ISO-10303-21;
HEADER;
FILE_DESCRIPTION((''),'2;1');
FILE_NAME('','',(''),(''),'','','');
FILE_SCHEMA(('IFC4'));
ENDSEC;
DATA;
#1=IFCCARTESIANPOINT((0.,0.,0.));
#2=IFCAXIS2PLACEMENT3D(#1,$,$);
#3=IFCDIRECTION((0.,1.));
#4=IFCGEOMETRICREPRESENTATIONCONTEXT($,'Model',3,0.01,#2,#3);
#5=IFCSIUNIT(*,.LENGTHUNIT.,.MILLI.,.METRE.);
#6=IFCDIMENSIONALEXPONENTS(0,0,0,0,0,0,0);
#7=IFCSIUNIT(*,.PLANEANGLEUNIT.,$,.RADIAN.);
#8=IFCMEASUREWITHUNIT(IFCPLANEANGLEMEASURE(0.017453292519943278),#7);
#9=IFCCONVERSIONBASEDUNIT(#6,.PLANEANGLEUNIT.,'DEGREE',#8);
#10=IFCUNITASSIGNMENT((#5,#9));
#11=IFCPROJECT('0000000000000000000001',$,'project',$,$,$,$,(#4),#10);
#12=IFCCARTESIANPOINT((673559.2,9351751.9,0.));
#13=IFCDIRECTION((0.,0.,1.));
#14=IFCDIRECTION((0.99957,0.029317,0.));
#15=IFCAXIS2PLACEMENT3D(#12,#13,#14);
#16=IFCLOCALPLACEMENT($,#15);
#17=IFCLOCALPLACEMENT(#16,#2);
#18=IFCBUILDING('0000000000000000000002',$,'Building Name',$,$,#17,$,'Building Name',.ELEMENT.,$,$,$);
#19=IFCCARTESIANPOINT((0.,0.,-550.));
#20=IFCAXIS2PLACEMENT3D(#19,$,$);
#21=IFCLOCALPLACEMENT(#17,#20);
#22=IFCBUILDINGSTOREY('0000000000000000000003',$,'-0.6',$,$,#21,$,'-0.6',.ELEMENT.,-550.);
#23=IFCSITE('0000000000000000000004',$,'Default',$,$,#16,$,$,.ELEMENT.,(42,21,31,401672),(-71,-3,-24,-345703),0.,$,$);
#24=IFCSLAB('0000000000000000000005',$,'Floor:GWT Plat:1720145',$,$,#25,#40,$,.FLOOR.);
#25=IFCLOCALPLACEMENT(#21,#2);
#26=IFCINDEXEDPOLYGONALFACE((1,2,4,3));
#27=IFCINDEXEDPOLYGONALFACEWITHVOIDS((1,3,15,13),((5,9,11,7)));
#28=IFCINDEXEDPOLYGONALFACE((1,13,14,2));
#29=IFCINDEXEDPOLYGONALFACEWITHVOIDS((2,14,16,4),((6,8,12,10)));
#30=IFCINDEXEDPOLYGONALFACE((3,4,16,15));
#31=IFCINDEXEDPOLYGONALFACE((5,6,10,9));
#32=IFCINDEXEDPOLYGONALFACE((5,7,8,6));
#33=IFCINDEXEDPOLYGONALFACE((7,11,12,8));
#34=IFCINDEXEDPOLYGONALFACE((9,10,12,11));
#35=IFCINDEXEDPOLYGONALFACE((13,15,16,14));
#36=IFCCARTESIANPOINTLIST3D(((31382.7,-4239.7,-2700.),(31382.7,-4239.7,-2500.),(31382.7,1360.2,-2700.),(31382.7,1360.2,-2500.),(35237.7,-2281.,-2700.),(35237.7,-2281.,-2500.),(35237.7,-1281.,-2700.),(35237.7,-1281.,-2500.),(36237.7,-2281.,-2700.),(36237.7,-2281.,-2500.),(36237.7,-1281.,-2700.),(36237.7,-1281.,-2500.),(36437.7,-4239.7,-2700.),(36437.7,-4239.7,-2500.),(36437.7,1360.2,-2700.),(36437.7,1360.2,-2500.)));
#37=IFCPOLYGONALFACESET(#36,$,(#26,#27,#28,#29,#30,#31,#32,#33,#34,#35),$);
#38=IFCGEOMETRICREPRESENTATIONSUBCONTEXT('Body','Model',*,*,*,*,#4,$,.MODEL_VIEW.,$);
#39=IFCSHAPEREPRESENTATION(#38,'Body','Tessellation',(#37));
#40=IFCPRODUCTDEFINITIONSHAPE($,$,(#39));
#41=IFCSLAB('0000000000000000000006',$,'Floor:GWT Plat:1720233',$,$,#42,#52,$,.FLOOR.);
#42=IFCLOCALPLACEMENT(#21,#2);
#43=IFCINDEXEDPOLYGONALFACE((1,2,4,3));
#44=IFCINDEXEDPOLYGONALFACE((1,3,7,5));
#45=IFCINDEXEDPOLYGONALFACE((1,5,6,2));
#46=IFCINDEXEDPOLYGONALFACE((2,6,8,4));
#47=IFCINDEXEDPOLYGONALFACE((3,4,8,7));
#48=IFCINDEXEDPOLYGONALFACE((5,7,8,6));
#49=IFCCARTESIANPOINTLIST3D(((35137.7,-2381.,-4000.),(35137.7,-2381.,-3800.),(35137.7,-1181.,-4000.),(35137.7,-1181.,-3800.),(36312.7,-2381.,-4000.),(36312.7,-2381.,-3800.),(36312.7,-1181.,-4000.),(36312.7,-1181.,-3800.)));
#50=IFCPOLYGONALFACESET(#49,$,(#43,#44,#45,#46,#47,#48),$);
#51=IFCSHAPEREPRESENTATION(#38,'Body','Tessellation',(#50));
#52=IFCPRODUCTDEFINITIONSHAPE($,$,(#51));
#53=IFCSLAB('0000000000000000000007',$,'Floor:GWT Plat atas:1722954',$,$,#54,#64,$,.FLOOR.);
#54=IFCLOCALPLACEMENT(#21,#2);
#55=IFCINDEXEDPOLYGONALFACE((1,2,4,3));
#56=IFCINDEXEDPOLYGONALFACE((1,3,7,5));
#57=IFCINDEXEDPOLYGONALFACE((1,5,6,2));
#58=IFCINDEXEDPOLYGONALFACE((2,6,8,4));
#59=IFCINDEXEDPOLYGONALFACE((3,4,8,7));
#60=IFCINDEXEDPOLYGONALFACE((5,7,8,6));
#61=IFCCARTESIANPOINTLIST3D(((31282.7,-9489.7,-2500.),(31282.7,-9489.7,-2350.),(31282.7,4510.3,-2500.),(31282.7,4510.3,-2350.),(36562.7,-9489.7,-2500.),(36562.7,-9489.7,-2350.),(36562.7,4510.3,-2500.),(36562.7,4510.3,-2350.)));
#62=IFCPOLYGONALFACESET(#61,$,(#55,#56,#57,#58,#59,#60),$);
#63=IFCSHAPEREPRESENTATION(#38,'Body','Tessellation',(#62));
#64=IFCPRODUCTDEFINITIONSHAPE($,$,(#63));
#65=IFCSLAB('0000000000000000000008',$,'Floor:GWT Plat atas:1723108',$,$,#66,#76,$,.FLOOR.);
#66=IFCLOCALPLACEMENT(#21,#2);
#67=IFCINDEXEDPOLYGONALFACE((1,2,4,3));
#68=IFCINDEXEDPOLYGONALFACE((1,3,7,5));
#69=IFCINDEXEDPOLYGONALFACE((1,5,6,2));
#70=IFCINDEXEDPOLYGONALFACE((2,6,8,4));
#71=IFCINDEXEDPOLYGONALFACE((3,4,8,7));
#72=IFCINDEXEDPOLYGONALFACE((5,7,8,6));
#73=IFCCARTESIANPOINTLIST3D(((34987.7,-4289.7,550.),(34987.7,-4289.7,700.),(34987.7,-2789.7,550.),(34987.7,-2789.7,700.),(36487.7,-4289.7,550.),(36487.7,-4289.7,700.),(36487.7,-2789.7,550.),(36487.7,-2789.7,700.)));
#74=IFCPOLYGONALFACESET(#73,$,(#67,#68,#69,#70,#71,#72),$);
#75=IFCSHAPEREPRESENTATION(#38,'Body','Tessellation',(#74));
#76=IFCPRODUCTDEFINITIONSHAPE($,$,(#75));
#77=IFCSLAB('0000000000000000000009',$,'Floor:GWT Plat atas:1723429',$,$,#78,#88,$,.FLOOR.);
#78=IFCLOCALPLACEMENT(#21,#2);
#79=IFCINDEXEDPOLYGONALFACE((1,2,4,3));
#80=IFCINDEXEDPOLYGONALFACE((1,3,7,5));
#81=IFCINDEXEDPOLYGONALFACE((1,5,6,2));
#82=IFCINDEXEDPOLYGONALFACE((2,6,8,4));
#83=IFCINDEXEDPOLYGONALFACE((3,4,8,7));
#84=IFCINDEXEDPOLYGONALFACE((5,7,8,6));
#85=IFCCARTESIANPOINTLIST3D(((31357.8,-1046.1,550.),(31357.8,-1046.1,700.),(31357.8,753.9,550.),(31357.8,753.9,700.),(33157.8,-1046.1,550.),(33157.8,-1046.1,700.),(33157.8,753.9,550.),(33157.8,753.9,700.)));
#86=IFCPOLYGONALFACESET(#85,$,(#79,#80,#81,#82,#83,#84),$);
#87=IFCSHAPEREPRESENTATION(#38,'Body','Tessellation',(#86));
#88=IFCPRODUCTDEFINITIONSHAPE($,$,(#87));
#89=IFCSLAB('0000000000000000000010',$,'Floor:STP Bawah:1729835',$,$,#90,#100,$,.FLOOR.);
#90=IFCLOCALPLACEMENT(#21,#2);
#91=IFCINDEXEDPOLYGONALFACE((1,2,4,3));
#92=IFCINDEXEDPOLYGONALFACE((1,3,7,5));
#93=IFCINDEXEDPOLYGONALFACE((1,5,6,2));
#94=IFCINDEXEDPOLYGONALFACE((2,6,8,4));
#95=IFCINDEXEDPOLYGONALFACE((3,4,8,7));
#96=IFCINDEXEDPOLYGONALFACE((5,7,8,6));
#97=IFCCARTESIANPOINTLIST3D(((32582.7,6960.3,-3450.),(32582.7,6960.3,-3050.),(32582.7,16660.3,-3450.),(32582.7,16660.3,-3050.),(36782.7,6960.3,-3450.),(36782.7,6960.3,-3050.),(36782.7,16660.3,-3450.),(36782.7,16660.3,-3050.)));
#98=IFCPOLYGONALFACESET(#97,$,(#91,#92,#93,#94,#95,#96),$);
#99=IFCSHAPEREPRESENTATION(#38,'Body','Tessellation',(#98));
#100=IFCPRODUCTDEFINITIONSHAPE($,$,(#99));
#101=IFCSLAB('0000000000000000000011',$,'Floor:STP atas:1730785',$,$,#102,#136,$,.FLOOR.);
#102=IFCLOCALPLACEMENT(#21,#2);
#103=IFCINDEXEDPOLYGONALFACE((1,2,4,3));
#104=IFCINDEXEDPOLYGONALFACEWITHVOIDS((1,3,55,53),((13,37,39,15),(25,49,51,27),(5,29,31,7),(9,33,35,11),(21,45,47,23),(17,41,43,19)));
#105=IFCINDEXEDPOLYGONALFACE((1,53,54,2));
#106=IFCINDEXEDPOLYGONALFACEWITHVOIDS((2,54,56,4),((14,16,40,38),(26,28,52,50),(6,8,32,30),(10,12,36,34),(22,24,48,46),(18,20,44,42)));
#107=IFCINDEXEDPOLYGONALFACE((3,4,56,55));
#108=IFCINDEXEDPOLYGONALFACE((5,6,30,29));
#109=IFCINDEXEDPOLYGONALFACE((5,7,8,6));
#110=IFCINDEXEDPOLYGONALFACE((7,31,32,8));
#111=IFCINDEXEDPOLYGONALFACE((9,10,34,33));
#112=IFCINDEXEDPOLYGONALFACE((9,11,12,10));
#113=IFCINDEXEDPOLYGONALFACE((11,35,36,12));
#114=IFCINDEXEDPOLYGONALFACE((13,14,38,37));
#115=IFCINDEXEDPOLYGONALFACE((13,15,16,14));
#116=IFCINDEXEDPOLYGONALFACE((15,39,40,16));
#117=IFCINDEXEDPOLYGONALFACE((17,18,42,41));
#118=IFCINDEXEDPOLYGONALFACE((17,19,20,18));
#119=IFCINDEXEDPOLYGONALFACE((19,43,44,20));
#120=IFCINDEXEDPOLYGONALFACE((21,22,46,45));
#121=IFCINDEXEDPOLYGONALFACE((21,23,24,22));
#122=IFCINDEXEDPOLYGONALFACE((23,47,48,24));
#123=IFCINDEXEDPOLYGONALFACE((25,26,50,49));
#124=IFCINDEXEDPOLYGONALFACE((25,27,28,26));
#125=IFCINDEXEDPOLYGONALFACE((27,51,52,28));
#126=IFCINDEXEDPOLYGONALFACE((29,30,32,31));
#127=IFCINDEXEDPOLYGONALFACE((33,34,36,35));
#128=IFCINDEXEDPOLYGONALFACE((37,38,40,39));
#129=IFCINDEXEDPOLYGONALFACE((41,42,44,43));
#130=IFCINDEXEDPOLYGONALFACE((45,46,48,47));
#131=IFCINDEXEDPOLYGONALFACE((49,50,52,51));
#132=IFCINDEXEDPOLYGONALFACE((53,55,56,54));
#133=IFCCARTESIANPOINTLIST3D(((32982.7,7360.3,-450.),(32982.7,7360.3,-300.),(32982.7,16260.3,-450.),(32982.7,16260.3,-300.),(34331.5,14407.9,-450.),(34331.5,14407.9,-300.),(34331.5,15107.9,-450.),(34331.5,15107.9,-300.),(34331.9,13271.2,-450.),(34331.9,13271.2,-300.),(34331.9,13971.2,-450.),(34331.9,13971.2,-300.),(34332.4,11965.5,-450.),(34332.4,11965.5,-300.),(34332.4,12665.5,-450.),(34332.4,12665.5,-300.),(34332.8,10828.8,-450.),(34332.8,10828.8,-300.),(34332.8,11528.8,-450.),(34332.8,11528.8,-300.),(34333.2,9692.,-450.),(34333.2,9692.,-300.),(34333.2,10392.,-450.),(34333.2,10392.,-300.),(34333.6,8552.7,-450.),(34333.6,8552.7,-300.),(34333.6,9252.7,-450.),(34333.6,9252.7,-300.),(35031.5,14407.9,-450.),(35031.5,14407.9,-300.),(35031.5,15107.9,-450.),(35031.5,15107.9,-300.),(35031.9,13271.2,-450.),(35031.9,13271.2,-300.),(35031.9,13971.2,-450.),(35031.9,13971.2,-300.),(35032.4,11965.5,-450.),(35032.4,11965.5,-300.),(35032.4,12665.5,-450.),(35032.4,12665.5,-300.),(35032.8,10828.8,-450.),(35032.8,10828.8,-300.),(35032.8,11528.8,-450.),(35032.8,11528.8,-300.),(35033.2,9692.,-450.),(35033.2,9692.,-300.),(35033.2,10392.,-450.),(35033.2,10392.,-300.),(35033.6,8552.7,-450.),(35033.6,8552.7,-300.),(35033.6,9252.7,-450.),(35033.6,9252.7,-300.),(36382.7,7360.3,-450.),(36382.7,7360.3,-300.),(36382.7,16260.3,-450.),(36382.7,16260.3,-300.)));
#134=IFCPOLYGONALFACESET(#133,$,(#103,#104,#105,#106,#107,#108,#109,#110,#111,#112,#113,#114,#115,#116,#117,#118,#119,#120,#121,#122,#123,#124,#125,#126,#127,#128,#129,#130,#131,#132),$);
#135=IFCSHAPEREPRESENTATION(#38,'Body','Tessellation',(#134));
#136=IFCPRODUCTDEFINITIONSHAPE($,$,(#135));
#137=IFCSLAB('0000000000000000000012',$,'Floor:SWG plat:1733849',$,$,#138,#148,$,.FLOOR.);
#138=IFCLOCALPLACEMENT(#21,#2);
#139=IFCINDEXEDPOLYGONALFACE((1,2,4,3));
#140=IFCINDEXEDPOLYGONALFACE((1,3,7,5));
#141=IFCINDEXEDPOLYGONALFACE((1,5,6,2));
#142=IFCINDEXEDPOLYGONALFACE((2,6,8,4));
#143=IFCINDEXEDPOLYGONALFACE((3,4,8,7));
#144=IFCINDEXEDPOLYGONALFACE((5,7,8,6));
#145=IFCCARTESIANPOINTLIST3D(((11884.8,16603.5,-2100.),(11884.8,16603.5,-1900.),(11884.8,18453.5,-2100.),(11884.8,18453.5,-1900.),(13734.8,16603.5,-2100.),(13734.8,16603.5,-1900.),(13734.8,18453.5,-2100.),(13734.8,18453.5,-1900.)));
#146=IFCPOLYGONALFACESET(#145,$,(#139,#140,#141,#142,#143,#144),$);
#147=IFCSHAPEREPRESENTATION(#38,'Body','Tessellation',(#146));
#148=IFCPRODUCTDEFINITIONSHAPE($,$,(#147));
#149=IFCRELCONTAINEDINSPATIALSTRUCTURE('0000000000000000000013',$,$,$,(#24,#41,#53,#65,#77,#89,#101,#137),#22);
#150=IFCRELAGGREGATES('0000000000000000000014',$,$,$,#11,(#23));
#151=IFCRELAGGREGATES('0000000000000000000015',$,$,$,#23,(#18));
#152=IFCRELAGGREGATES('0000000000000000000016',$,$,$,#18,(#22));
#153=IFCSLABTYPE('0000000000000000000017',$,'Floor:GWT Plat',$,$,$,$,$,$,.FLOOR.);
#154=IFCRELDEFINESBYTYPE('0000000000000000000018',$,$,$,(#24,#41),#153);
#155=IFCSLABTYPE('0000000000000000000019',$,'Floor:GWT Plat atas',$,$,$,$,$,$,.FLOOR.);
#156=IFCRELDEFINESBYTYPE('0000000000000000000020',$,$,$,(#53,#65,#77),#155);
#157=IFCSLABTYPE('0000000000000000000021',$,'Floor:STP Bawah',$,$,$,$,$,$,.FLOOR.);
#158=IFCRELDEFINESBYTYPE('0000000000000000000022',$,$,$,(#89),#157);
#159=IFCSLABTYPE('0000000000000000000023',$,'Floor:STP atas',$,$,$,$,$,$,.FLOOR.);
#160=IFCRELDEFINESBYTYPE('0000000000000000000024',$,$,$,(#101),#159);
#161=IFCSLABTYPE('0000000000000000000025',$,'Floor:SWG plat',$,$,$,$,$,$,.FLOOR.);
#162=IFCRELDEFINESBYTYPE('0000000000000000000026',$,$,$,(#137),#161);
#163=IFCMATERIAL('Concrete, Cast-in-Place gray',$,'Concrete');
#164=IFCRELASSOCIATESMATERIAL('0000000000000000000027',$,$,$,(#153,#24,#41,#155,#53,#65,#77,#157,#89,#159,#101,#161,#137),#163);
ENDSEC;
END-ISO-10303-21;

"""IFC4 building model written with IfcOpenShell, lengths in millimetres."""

from ifc_helpers import new_model, entity, si_unit, converted_unit, direction, frame, origin, place, context, subcontext, project, spatial, indexed_curve, outline, extrude, material, type_object, element, save


model = new_model("IFC4")

# Units and contexts
model_context = context("Model", 3, precision=0.01, world=origin(), true_north=direction((0.0, 1.0)))
body_context = subcontext(model_context, "Body", "Model", "MODEL_VIEW")
ifc_project = project(units=[si_unit("LENGTHUNIT", "METRE", prefix="MILLI"), converted_unit("PLANEANGLEUNIT", "DEGREE", entity("IfcPlaneAngleMeasure", 0.017453292519943278), si_unit("PLANEANGLEUNIT", "RADIAN"), dimensions=[0, 0, 0, 0, 0, 0, 0])], contexts=[model_context])

# Site, building, storey
site_placement = place(None, frame((673559.2, 9351751.9, 0.0), z_axis=(0.0, 0.0, 1.0), x_axis=(0.99957, 0.029317, 0.0)))
site = spatial("IfcSite", under=ifc_project, at=site_placement, Name="Default", CompositionType="ELEMENT", RefLatitude=(42, 21, 31, 401672), RefLongitude=(-71, -3, -24, -345703), RefElevation=0.0)
building_placement = place(site_placement, origin())
building = spatial("IfcBuilding", under=site, at=building_placement, Name="Building Name", LongName="Building Name", CompositionType="ELEMENT")
storey_placement = place(building_placement, frame((0.0, 0.0, -550.0)))
storey = spatial("IfcBuildingStorey", under=building, at=storey_placement, Name="-0.6", LongName="-0.6", CompositionType="ELEMENT", Elevation=-550.0)

# Shared definitions
ifc_material = material(Name="Concrete, Cast-in-Place gray", Category="Concrete")

# Slab, opening
slab_type_1 = type_object("IfcSlabType", Name="Floor:GWT Plat", PredefinedType="FLOOR", material=ifc_material)
slab_1_placement = place(storey_placement, origin())
slab_1 = element("IfcSlab", 1, at=slab_1_placement, inside=storey, type_object=slab_type_1, material=ifc_material, Name="Floor:GWT Plat:1720145", PredefinedType="FLOOR", context=body_context, shape_type="SweptSolid", body=[
    extrude(outline(indexed_curve([(-2527.5, -2799.9), (2527.5, -2799.9), (2527.5, -2699.9), (2527.5, 2699.9), (2527.5, 2799.9), (-2527.5, 2799.9), (-2527.5, 2699.9), (-2527.5, -2699.9), (-2527.5, -2799.9)], self_intersect=False), holes=[indexed_curve([(-2327.5, -158.8), (-2327.5, 841.2), (-1327.5, 841.2), (-1327.5, -158.8), (-2327.5, -158.8)], self_intersect=False)]), frame((33910.2, -1439.7, -2700.0), z_axis=(0.0, 0.0, 1.0), x_axis=(-1.0, 0.0, 0.0)), (0.0, 0.0, 1.0), 200.0),
])
opening_1_placement = place(slab_1_placement, origin())
element("IfcOpeningElement", 2, at=opening_1_placement, cuts=slab_1, PredefinedType="OPENING", context=body_context, shape_type="SweptSolid", body=[
    extrude(outline(indexed_curve([(36237.7, -1281.0), (35237.7, -1281.0), (35237.7, -2281.0), (36237.7, -2281.0), (36237.7, -1281.0)], self_intersect=False)), frame((0.0, 0.0, 550.0)), (0.0, 0.0, -1.0), 5599.9),
])

# Slabs
slab_2_placement = place(storey_placement, origin())
element("IfcSlab", 3, at=slab_2_placement, inside=storey, type_object=slab_type_1, material=ifc_material, Name="Floor:GWT Plat:1720233", PredefinedType="FLOOR", context=body_context, shape_type="SweptSolid", body=[
    extrude(outline(indexed_curve([(-600.0, -587.5), (600.0, -587.5), (600.0, 587.5), (-600.0, 587.5), (-600.0, -587.5)], self_intersect=False)), frame((35725.2, -1781.0, -3800.0), z_axis=(0.0, 0.0, -1.0), x_axis=(0.0, 1.0, 0.0)), (0.0, 0.0, 1.0), 200.0),
])
slab_type_2 = type_object("IfcSlabType", Name="Floor:GWT Plat atas", PredefinedType="FLOOR", material=ifc_material)
slab_3_placement = place(storey_placement, origin())
element("IfcSlab", 4, at=slab_3_placement, inside=storey, type_object=slab_type_2, material=ifc_material, Name="Floor:GWT Plat atas:1722954", PredefinedType="FLOOR", context=body_context, shape_type="SweptSolid", body=[
    extrude(outline(indexed_curve([(-7000.0, -2640.0), (7000.0, -2640.0), (7000.0, 2640.0), (-7000.0, 2640.0), (-7000.0, -2640.0)], self_intersect=False)), frame((33922.7, -2489.7, -2350.0), z_axis=(0.0, 0.0, -1.0), x_axis=(0.0, 1.0, 0.0)), (0.0, 0.0, 1.0), 150.0),
])

# Slabs
slab_4_placement = place(storey_placement, origin())
element("IfcSlab", 5, at=slab_4_placement, inside=storey, type_object=slab_type_2, material=ifc_material, Name="Floor:GWT Plat atas:1723108", PredefinedType="FLOOR", context=body_context, shape_type="SweptSolid", body=[
    extrude(outline(indexed_curve([(-750.0, -750.0), (750.0, -750.0), (750.0, 750.0), (-750.0, 750.0), (-750.0, -750.0)], self_intersect=False)), frame((35737.7, -3539.7, 700.0), z_axis=(0.0, 0.0, -1.0), x_axis=(0.0, 1.0, 0.0)), (0.0, 0.0, 1.0), 150.0),
])
slab_5_placement = place(storey_placement, origin())
element("IfcSlab", 6, at=slab_5_placement, inside=storey, type_object=slab_type_2, material=ifc_material, Name="Floor:GWT Plat atas:1723429", PredefinedType="FLOOR", context=body_context, shape_type="SweptSolid", body=[
    extrude(outline(indexed_curve([(-900.0, -900.0), (900.0, -900.0), (900.0, 900.0), (-900.0, 900.0), (-900.0, -900.0)], self_intersect=False)), frame((32257.8, -146.1, 700.0), z_axis=(0.0, 0.0, -1.0), x_axis=(0.0, 1.0, 0.0)), (0.0, 0.0, 1.0), 150.0),
])
slab_type_3 = type_object("IfcSlabType", Name="Floor:STP Bawah", PredefinedType="FLOOR", material=ifc_material)
slab_6_placement = place(storey_placement, origin())
element("IfcSlab", 7, at=slab_6_placement, inside=storey, type_object=slab_type_3, material=ifc_material, Name="Floor:STP Bawah:1729835", PredefinedType="FLOOR", context=body_context, shape_type="SweptSolid", body=[
    extrude(outline(indexed_curve([(-4850.0, -2100.0), (4850.0, -2100.0), (4850.0, 2100.0), (-4850.0, 2100.0), (-4850.0, -2100.0)], self_intersect=False)), frame((34682.7, 11810.3, -3050.0), z_axis=(0.0, 0.0, -1.0), x_axis=(0.0, 1.0, 0.0)), (0.0, 0.0, 1.0), 400.0),
])

# Slab, openings
slab_type_4 = type_object("IfcSlabType", Name="Floor:STP atas", PredefinedType="FLOOR", material=ifc_material)
slab_7_placement = place(storey_placement, origin())
slab_7 = element("IfcSlab", 8, at=slab_7_placement, inside=storey, type_object=slab_type_4, material=ifc_material, Name="Floor:STP atas:1730785", PredefinedType="FLOOR", context=body_context, shape_type="SweptSolid", body=[
    extrude(outline(indexed_curve([(-4450.0, -1700.0), (4450.0, -1700.0), (4450.0, 1700.0), (-4450.0, 1700.0), (-4450.0, -1700.0)], self_intersect=False), holes=[indexed_curve([(-3297.6, 348.8), (-2597.6, 348.8), (-2597.6, -351.2), (-3297.6, -351.2), (-3297.6, 348.8)], self_intersect=False), indexed_curve([(-2160.9, 349.2), (-1460.9, 349.2), (-1460.9, -350.8), (-2160.9, -350.8), (-2160.9, 349.2)], self_intersect=False), indexed_curve([(-855.2, 349.7), (-155.2, 349.7), (-155.2, -350.3), (-855.2, -350.3), (-855.2, 349.7)], self_intersect=False), indexed_curve([(281.5, 350.1), (981.5, 350.1), (981.5, -349.9), (281.5, -349.9), (281.5, 350.1)], self_intersect=False), indexed_curve([(1418.3, 350.5), (2118.3, 350.5), (2118.3, -349.5), (1418.3, -349.5), (1418.3, 350.5)], self_intersect=False), indexed_curve([(2557.7, 351.0), (3257.7, 351.0), (3257.7, -349.0), (2557.7, -349.0), (2557.7, 351.0)], self_intersect=False)]), frame((34682.7, 11810.3, -450.0), z_axis=(0.0, 0.0, 1.0), x_axis=(0.0, -1.0, 0.0)), (0.0, 0.0, 1.0), 150.0),
])
opening_2_placement = place(slab_7_placement, origin())
element("IfcOpeningElement", 9, at=opening_2_placement, cuts=slab_7, PredefinedType="OPENING", context=body_context, shape_type="SweptSolid", body=[
    extrude(outline(indexed_curve([(35031.5, 15107.9), (34331.5, 15107.9), (34331.5, 14407.9), (35031.5, 14407.9), (35031.5, 15107.9)], self_intersect=False)), frame((0.0, 0.0, 550.0)), (0.0, 0.0, -1.0), 3400.0),
])
opening_3_placement = place(slab_7_placement, origin())
element("IfcOpeningElement", 10, at=opening_3_placement, cuts=slab_7, PredefinedType="OPENING", context=body_context, shape_type="SweptSolid", body=[
    extrude(outline(indexed_curve([(35031.9, 13971.2), (34331.9, 13971.2), (34331.9, 13271.2), (35031.9, 13271.2), (35031.9, 13971.2)], self_intersect=False)), frame((0.0, 0.0, 550.0)), (0.0, 0.0, -1.0), 3400.0),
])
opening_4_placement = place(slab_7_placement, origin())
element("IfcOpeningElement", 11, at=opening_4_placement, cuts=slab_7, PredefinedType="OPENING", context=body_context, shape_type="SweptSolid", body=[
    extrude(outline(indexed_curve([(35032.4, 12665.5), (34332.4, 12665.5), (34332.4, 11965.5), (35032.4, 11965.5), (35032.4, 12665.5)], self_intersect=False)), frame((0.0, 0.0, 550.0)), (0.0, 0.0, -1.0), 3400.0),
])
opening_5_placement = place(slab_7_placement, origin())
element("IfcOpeningElement", 12, at=opening_5_placement, cuts=slab_7, PredefinedType="OPENING", context=body_context, shape_type="SweptSolid", body=[
    extrude(outline(indexed_curve([(35032.8, 11528.8), (34332.8, 11528.8), (34332.8, 10828.8), (35032.8, 10828.8), (35032.8, 11528.8)], self_intersect=False)), frame((0.0, 0.0, 550.0)), (0.0, 0.0, -1.0), 3400.0),
])
opening_6_placement = place(slab_7_placement, origin())
element("IfcOpeningElement", 13, at=opening_6_placement, cuts=slab_7, PredefinedType="OPENING", context=body_context, shape_type="SweptSolid", body=[
    extrude(outline(indexed_curve([(35033.2, 10392.0), (34333.2, 10392.0), (34333.2, 9692.0), (35033.2, 9692.0), (35033.2, 10392.0)], self_intersect=False)), frame((0.0, 0.0, 550.0)), (0.0, 0.0, -1.0), 3400.0),
])
opening_7_placement = place(slab_7_placement, origin())
element("IfcOpeningElement", 14, at=opening_7_placement, cuts=slab_7, PredefinedType="OPENING", context=body_context, shape_type="SweptSolid", body=[
    extrude(outline(indexed_curve([(35033.6, 9252.7), (34333.6, 9252.7), (34333.6, 8552.7), (35033.6, 8552.7), (35033.6, 9252.7)], self_intersect=False)), frame((0.0, 0.0, 550.0)), (0.0, 0.0, -1.0), 3400.0),
])

# Slab
slab_type_5 = type_object("IfcSlabType", Name="Floor:SWG plat", PredefinedType="FLOOR", material=ifc_material)
slab_8_placement = place(storey_placement, origin())
element("IfcSlab", 15, at=slab_8_placement, inside=storey, type_object=slab_type_5, material=ifc_material, Name="Floor:SWG plat:1733849", PredefinedType="FLOOR", context=body_context, shape_type="SweptSolid", body=[
    extrude(outline(indexed_curve([(-925.0, -925.0), (925.0, -925.0), (925.0, 925.0), (-925.0, 925.0), (-925.0, -925.0)], self_intersect=False)), frame((12809.8, 17528.5, -1900.0), z_axis=(0.0, 0.0, -1.0), x_axis=(0.0, 1.0, 0.0)), (0.0, 0.0, 1.0), 200.0),
])

save(model, "model.ifc")
